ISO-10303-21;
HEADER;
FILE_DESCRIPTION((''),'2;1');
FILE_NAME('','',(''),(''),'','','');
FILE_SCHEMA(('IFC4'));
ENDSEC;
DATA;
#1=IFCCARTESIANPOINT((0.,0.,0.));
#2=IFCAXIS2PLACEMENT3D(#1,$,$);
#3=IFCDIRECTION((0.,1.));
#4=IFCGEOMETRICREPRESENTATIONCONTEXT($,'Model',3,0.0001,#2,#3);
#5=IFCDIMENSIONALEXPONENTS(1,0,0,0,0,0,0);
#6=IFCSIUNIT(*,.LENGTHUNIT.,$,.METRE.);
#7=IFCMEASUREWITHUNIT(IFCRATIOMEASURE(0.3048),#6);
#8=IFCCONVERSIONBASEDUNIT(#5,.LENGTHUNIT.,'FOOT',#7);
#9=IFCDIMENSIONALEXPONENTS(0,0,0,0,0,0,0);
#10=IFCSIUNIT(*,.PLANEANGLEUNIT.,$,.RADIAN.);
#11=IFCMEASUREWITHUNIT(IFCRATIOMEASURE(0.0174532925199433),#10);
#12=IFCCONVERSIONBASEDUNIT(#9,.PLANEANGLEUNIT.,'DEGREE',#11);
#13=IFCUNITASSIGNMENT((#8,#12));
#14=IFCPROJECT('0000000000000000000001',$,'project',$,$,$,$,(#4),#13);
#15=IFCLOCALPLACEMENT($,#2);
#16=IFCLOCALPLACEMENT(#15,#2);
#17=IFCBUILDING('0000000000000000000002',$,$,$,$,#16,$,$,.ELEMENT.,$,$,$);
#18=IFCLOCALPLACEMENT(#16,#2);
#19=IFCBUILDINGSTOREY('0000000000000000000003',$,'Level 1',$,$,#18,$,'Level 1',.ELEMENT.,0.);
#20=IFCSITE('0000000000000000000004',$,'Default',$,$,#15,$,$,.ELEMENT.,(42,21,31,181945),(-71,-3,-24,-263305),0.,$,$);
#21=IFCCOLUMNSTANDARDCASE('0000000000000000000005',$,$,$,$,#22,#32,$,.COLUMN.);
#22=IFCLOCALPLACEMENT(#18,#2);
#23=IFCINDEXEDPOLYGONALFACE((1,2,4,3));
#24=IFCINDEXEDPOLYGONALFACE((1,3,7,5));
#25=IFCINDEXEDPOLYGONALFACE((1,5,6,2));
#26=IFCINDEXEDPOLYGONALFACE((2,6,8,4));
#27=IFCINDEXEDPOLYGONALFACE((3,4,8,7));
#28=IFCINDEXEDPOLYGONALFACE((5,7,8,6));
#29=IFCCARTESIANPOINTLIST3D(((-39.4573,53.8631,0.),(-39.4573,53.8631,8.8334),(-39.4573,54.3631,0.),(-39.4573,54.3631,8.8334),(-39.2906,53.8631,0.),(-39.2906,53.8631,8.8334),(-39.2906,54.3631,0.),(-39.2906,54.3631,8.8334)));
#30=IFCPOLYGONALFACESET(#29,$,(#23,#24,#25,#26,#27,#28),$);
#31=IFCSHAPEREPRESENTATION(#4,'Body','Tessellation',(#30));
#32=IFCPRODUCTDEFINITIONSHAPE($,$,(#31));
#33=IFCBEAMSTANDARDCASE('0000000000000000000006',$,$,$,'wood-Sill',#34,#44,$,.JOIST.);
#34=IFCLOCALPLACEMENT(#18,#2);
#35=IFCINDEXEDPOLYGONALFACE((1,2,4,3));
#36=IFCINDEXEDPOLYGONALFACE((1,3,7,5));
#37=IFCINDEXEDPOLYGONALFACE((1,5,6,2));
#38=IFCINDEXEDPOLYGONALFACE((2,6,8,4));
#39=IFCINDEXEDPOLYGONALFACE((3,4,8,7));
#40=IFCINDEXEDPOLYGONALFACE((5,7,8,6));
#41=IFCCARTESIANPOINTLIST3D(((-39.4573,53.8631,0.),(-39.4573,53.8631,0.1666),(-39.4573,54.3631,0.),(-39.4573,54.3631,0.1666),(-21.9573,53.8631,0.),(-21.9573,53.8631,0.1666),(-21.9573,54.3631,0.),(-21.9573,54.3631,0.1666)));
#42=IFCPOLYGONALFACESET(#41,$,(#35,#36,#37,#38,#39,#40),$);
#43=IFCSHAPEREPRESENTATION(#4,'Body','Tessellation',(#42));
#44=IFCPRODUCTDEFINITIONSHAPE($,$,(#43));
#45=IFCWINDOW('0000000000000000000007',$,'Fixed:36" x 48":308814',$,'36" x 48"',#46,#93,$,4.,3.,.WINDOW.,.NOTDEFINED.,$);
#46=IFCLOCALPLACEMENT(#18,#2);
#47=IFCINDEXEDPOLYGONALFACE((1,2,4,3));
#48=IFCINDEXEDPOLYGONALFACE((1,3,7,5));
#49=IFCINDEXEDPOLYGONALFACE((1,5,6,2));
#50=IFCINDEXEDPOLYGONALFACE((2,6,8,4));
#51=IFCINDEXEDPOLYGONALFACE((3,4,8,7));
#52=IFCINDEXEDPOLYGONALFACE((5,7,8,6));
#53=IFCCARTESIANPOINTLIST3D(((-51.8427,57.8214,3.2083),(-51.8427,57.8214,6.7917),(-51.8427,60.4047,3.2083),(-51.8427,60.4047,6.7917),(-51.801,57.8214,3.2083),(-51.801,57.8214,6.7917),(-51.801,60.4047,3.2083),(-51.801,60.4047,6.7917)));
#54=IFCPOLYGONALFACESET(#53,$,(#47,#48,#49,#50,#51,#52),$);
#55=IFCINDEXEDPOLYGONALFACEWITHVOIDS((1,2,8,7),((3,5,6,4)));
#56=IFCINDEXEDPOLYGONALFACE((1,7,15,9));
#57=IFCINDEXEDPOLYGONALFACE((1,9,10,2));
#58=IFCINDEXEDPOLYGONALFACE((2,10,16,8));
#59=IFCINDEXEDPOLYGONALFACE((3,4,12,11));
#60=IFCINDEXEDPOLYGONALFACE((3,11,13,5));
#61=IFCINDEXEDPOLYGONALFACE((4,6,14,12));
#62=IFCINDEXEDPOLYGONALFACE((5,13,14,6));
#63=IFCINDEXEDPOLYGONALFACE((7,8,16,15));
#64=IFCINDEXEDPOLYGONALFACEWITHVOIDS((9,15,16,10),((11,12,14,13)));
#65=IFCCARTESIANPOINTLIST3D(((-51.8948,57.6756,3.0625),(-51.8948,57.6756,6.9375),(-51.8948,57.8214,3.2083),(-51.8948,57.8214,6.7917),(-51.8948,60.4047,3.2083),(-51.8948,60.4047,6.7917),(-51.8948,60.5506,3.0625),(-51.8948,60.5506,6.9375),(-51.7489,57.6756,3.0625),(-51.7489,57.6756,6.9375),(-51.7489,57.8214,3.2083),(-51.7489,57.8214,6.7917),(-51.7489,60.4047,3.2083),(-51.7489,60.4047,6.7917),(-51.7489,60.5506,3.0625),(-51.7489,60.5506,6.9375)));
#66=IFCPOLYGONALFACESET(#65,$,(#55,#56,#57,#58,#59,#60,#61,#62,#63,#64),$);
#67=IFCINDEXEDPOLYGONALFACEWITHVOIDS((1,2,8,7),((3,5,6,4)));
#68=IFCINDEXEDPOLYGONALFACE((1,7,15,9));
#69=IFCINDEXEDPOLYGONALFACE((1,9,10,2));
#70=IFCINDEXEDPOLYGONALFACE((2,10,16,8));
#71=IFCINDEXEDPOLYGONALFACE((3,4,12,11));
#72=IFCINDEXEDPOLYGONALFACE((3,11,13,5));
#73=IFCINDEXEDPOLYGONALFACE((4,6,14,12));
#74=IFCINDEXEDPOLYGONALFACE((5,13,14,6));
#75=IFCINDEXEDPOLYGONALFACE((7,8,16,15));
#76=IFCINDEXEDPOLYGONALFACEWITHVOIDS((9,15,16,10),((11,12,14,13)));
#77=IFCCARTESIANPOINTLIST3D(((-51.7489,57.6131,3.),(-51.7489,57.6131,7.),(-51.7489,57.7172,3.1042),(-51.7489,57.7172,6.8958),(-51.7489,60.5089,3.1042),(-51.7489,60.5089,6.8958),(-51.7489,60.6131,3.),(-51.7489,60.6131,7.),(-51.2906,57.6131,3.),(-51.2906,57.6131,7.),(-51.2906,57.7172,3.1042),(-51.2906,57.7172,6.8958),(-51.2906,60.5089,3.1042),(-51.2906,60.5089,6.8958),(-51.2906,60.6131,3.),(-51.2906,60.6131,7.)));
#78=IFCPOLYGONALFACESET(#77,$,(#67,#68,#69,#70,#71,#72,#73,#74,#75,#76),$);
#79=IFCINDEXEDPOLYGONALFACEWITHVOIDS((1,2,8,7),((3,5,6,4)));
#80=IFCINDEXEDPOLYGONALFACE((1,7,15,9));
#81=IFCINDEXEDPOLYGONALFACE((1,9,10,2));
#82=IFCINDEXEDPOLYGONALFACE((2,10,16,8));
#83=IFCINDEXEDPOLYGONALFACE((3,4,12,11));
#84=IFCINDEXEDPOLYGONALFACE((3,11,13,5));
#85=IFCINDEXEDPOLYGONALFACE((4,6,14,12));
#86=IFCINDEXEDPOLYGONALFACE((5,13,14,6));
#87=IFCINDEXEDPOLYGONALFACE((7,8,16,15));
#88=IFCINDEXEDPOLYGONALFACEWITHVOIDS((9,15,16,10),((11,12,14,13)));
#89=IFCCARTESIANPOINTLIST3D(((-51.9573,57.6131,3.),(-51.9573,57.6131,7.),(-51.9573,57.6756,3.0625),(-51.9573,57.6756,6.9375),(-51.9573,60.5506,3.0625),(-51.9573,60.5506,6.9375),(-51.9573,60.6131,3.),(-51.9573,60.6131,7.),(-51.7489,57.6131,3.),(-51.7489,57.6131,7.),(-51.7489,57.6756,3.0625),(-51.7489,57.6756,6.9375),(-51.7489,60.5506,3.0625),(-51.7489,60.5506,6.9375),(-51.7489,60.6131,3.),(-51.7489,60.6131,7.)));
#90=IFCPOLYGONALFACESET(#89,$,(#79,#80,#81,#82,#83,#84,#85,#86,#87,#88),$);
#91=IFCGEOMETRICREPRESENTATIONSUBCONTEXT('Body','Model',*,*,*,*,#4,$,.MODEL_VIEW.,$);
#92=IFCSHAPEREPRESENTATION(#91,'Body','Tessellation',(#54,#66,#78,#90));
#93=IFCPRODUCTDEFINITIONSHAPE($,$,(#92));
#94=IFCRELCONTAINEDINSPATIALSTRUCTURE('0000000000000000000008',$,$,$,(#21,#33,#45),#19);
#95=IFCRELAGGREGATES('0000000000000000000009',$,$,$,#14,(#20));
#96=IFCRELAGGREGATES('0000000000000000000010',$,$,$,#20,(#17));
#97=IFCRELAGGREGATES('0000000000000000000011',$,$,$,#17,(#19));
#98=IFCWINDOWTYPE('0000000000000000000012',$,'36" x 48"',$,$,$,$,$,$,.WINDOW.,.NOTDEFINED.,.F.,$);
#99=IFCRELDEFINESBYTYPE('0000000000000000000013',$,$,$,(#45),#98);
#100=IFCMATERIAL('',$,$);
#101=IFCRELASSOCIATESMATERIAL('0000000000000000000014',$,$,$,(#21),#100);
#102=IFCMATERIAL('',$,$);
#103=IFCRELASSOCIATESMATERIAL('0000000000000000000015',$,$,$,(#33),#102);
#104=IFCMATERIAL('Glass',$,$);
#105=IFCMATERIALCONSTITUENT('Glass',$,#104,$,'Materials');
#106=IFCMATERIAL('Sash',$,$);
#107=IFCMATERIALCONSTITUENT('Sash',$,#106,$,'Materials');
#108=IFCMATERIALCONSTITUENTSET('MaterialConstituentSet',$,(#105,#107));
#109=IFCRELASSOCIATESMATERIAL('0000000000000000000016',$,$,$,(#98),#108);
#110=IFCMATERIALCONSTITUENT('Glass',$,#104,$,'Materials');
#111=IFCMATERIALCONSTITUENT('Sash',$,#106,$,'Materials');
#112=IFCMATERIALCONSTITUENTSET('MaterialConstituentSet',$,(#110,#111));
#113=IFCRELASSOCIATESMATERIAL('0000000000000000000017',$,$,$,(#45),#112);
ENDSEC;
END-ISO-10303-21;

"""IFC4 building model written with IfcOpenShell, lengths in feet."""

from ifc_helpers import new_model, entity, si_unit, converted_unit, direction, frame, frame_2d, origin, origin_with_axes, place, context, subcontext, project, spatial, polyline, rectangle, outline, extrude, source, transform, mapped, material, constituent, constituent_set, type_object, type_shapes, element, save


model = new_model("IFC4")

# Units and contexts
model_context = context("Model", 3, precision=0.0001, world=origin(), true_north=direction((0.0, 1.0)))
body_context = subcontext(model_context, "Body", "Model", "MODEL_VIEW")
ifc_project = project(units=[converted_unit("LENGTHUNIT", "FOOT", entity("IfcRatioMeasure", 0.3048), si_unit("LENGTHUNIT", "METRE"), dimensions=[1, 0, 0, 0, 0, 0, 0]), converted_unit("PLANEANGLEUNIT", "DEGREE", entity("IfcRatioMeasure", 0.0174532925199433), si_unit("PLANEANGLEUNIT", "RADIAN"), dimensions=[0, 0, 0, 0, 0, 0, 0])], contexts=[model_context])

# Site, building, storey
site_placement = place(None, origin())
site = spatial("IfcSite", under=ifc_project, at=site_placement, Name="Default", CompositionType="ELEMENT", RefLatitude=(42, 21, 31, 181945), RefLongitude=(-71, -3, -24, -263305), RefElevation=0.0)
building_placement = place(site_placement, origin())
building = spatial("IfcBuilding", under=site, at=building_placement, CompositionType="ELEMENT")
storey_placement = place(building_placement, origin())
storey = spatial("IfcBuildingStorey", under=building, at=storey_placement, Name="Level 1", LongName="Level 1", CompositionType="ELEMENT", Elevation=0.0)

# Column
placement_1 = place(storey_placement, frame((-51.6239, 66.9464, 0.0), z_axis=(0.0, 0.0, 1.0), x_axis=(0.0, -1.0, 0.0)))
ifc_material_1 = material(Name="")
placement_2 = place(storey_placement, frame((-39.4573, 54.1131, 0.0)))
column_placement = place(placement_2, frame((0.0833, 0.0, 0.0), z_axis=(0.0, 0.0, 1.0), x_axis=(1.0, 0.0, 0.0)))
element("IfcColumnStandardCase", 1, at=column_placement, inside=storey, material=ifc_material_1, PredefinedType="COLUMN", context=model_context, shape_type="SweptSolid", body=[
    extrude(rectangle(XDim=0.1667, YDim=0.5), origin(), (0.0, 0.0, 1.0), 8.8334),
])

# Beam
ifc_material_2 = material(Name="")
beam_1_placement = place(placement_2, frame((0.0, 0.0, 0.0833), z_axis=(1.0, 0.0, 0.0), x_axis=(0.0, 0.0, 1.0)))
element("IfcBeamStandardCase", 2, at=beam_1_placement, inside=storey, material=ifc_material_2, ObjectType="wood-Sill", PredefinedType="JOIST", context=model_context, shape_type="SweptSolid", body=[
    extrude(rectangle(XDim=0.1667, YDim=0.5), origin_with_axes(), (0.0, 0.0, 1.0), 17.5),
])

# Window
ifc_material_3 = material(Name="Glass")
ifc_constituent_1 = constituent(ifc_material_3, Name="Glass", Category="Materials")
ifc_material_4 = material(Name="Sash")
ifc_constituent_2 = constituent(ifc_material_4, Name="Sash", Category="Materials")
ifc_constituent_set_1 = constituent_set(constituents=[ifc_constituent_1, ifc_constituent_2], Name="MaterialConstituentSet")
ifc_constituent_3 = constituent(ifc_material_3, Name="Glass", Category="Materials")
ifc_constituent_4 = constituent(ifc_material_4, Name="Sash", Category="Materials")
ifc_constituent_set_2 = constituent_set(constituents=[ifc_constituent_3, ifc_constituent_4], Name="MaterialConstituentSet")
window_type = type_object("IfcWindowType", Name="36\" x 48\"", ParameterTakesPrecedence=False, PartitioningType="NOTDEFINED", PredefinedType="WINDOW", material=ifc_constituent_set_2)
shared_shape = source(origin(), body_context, "Body", "SweptSolid", [
    extrude(rectangle(XDim=0.0417, YDim=2.5833, at=frame_2d((0.0, 0.0), x_axis=(1.0, 0.0))), frame((1.5, 0.5312, 0.2083), z_axis=(0.0, 0.0, 1.0), x_axis=(0.0, 1.0, 0.0)), (0.0, 0.0, 1.0), 3.5833),
    extrude(outline(polyline([(-1.4375, -1.9375), (1.4375, -1.9375), (1.4375, 1.9375), (-1.4375, 1.9375), (-1.4375, -1.9375)]), holes=[polyline([(-1.2917, -1.7917), (-1.2917, 1.7917), (1.2917, 1.7917), (1.2917, -1.7917), (-1.2917, -1.7917)])]), frame((1.5, 0.4583, 2.0), z_axis=(0.0, 1.0, 0.0), x_axis=(1.0, 0.0, 0.0)), (0.0, 0.0, 1.0), 0.1458),
    extrude(outline(polyline([(-1.5, -2.0), (1.5, -2.0), (1.5, 2.0), (-1.5, 2.0), (-1.5, -2.0)]), holes=[polyline([(-1.3958, -1.8958), (-1.3958, 1.8958), (1.3958, 1.8958), (1.3958, -1.8958), (-1.3958, -1.8958)])]), frame((1.5, 0.0, 2.0), z_axis=(0.0, 1.0, 0.0), x_axis=(1.0, 0.0, 0.0)), (0.0, 0.0, 1.0), 0.4583),
    extrude(outline(polyline([(-2.0, -1.5), (2.0, -1.5), (2.0, 1.5), (-2.0, 1.5), (-2.0, -1.5)]), holes=[polyline([(-1.9375, -1.4375), (-1.9375, 1.4375), (1.9375, 1.4375), (1.9375, -1.4375), (-1.9375, -1.4375)])]), frame((1.5, 0.4583, 2.0), z_axis=(0.0, 1.0, 0.0), x_axis=(0.0, 0.0, -1.0)), (0.0, 0.0, 1.0), 0.2083),
])
type_shapes(window_type, [shared_shape])
placement_3 = place(placement_1, frame((9.3333, 0.3333, 3.0)))
window_placement = place(placement_3, frame((0.0, 0.0, 0.0), z_axis=(0.0, 0.0, 1.0), x_axis=(-1.0, 0.0, 0.0)))
element("IfcWindow", 3, at=window_placement, inside=storey, type_object=window_type, material=ifc_constituent_set_1, Name="Fixed:36\" x 48\":308814", ObjectType="36\" x 48\"", OverallHeight=4.0, OverallWidth=3.0, PartitioningType="NOTDEFINED", PredefinedType="WINDOW", context=body_context, shape_type="MappedRepresentation", body=[
    mapped(shared_shape, transform((0.0, 0.0, 0.0), scale=1.0)),
])

save(model, "model.ifc")
